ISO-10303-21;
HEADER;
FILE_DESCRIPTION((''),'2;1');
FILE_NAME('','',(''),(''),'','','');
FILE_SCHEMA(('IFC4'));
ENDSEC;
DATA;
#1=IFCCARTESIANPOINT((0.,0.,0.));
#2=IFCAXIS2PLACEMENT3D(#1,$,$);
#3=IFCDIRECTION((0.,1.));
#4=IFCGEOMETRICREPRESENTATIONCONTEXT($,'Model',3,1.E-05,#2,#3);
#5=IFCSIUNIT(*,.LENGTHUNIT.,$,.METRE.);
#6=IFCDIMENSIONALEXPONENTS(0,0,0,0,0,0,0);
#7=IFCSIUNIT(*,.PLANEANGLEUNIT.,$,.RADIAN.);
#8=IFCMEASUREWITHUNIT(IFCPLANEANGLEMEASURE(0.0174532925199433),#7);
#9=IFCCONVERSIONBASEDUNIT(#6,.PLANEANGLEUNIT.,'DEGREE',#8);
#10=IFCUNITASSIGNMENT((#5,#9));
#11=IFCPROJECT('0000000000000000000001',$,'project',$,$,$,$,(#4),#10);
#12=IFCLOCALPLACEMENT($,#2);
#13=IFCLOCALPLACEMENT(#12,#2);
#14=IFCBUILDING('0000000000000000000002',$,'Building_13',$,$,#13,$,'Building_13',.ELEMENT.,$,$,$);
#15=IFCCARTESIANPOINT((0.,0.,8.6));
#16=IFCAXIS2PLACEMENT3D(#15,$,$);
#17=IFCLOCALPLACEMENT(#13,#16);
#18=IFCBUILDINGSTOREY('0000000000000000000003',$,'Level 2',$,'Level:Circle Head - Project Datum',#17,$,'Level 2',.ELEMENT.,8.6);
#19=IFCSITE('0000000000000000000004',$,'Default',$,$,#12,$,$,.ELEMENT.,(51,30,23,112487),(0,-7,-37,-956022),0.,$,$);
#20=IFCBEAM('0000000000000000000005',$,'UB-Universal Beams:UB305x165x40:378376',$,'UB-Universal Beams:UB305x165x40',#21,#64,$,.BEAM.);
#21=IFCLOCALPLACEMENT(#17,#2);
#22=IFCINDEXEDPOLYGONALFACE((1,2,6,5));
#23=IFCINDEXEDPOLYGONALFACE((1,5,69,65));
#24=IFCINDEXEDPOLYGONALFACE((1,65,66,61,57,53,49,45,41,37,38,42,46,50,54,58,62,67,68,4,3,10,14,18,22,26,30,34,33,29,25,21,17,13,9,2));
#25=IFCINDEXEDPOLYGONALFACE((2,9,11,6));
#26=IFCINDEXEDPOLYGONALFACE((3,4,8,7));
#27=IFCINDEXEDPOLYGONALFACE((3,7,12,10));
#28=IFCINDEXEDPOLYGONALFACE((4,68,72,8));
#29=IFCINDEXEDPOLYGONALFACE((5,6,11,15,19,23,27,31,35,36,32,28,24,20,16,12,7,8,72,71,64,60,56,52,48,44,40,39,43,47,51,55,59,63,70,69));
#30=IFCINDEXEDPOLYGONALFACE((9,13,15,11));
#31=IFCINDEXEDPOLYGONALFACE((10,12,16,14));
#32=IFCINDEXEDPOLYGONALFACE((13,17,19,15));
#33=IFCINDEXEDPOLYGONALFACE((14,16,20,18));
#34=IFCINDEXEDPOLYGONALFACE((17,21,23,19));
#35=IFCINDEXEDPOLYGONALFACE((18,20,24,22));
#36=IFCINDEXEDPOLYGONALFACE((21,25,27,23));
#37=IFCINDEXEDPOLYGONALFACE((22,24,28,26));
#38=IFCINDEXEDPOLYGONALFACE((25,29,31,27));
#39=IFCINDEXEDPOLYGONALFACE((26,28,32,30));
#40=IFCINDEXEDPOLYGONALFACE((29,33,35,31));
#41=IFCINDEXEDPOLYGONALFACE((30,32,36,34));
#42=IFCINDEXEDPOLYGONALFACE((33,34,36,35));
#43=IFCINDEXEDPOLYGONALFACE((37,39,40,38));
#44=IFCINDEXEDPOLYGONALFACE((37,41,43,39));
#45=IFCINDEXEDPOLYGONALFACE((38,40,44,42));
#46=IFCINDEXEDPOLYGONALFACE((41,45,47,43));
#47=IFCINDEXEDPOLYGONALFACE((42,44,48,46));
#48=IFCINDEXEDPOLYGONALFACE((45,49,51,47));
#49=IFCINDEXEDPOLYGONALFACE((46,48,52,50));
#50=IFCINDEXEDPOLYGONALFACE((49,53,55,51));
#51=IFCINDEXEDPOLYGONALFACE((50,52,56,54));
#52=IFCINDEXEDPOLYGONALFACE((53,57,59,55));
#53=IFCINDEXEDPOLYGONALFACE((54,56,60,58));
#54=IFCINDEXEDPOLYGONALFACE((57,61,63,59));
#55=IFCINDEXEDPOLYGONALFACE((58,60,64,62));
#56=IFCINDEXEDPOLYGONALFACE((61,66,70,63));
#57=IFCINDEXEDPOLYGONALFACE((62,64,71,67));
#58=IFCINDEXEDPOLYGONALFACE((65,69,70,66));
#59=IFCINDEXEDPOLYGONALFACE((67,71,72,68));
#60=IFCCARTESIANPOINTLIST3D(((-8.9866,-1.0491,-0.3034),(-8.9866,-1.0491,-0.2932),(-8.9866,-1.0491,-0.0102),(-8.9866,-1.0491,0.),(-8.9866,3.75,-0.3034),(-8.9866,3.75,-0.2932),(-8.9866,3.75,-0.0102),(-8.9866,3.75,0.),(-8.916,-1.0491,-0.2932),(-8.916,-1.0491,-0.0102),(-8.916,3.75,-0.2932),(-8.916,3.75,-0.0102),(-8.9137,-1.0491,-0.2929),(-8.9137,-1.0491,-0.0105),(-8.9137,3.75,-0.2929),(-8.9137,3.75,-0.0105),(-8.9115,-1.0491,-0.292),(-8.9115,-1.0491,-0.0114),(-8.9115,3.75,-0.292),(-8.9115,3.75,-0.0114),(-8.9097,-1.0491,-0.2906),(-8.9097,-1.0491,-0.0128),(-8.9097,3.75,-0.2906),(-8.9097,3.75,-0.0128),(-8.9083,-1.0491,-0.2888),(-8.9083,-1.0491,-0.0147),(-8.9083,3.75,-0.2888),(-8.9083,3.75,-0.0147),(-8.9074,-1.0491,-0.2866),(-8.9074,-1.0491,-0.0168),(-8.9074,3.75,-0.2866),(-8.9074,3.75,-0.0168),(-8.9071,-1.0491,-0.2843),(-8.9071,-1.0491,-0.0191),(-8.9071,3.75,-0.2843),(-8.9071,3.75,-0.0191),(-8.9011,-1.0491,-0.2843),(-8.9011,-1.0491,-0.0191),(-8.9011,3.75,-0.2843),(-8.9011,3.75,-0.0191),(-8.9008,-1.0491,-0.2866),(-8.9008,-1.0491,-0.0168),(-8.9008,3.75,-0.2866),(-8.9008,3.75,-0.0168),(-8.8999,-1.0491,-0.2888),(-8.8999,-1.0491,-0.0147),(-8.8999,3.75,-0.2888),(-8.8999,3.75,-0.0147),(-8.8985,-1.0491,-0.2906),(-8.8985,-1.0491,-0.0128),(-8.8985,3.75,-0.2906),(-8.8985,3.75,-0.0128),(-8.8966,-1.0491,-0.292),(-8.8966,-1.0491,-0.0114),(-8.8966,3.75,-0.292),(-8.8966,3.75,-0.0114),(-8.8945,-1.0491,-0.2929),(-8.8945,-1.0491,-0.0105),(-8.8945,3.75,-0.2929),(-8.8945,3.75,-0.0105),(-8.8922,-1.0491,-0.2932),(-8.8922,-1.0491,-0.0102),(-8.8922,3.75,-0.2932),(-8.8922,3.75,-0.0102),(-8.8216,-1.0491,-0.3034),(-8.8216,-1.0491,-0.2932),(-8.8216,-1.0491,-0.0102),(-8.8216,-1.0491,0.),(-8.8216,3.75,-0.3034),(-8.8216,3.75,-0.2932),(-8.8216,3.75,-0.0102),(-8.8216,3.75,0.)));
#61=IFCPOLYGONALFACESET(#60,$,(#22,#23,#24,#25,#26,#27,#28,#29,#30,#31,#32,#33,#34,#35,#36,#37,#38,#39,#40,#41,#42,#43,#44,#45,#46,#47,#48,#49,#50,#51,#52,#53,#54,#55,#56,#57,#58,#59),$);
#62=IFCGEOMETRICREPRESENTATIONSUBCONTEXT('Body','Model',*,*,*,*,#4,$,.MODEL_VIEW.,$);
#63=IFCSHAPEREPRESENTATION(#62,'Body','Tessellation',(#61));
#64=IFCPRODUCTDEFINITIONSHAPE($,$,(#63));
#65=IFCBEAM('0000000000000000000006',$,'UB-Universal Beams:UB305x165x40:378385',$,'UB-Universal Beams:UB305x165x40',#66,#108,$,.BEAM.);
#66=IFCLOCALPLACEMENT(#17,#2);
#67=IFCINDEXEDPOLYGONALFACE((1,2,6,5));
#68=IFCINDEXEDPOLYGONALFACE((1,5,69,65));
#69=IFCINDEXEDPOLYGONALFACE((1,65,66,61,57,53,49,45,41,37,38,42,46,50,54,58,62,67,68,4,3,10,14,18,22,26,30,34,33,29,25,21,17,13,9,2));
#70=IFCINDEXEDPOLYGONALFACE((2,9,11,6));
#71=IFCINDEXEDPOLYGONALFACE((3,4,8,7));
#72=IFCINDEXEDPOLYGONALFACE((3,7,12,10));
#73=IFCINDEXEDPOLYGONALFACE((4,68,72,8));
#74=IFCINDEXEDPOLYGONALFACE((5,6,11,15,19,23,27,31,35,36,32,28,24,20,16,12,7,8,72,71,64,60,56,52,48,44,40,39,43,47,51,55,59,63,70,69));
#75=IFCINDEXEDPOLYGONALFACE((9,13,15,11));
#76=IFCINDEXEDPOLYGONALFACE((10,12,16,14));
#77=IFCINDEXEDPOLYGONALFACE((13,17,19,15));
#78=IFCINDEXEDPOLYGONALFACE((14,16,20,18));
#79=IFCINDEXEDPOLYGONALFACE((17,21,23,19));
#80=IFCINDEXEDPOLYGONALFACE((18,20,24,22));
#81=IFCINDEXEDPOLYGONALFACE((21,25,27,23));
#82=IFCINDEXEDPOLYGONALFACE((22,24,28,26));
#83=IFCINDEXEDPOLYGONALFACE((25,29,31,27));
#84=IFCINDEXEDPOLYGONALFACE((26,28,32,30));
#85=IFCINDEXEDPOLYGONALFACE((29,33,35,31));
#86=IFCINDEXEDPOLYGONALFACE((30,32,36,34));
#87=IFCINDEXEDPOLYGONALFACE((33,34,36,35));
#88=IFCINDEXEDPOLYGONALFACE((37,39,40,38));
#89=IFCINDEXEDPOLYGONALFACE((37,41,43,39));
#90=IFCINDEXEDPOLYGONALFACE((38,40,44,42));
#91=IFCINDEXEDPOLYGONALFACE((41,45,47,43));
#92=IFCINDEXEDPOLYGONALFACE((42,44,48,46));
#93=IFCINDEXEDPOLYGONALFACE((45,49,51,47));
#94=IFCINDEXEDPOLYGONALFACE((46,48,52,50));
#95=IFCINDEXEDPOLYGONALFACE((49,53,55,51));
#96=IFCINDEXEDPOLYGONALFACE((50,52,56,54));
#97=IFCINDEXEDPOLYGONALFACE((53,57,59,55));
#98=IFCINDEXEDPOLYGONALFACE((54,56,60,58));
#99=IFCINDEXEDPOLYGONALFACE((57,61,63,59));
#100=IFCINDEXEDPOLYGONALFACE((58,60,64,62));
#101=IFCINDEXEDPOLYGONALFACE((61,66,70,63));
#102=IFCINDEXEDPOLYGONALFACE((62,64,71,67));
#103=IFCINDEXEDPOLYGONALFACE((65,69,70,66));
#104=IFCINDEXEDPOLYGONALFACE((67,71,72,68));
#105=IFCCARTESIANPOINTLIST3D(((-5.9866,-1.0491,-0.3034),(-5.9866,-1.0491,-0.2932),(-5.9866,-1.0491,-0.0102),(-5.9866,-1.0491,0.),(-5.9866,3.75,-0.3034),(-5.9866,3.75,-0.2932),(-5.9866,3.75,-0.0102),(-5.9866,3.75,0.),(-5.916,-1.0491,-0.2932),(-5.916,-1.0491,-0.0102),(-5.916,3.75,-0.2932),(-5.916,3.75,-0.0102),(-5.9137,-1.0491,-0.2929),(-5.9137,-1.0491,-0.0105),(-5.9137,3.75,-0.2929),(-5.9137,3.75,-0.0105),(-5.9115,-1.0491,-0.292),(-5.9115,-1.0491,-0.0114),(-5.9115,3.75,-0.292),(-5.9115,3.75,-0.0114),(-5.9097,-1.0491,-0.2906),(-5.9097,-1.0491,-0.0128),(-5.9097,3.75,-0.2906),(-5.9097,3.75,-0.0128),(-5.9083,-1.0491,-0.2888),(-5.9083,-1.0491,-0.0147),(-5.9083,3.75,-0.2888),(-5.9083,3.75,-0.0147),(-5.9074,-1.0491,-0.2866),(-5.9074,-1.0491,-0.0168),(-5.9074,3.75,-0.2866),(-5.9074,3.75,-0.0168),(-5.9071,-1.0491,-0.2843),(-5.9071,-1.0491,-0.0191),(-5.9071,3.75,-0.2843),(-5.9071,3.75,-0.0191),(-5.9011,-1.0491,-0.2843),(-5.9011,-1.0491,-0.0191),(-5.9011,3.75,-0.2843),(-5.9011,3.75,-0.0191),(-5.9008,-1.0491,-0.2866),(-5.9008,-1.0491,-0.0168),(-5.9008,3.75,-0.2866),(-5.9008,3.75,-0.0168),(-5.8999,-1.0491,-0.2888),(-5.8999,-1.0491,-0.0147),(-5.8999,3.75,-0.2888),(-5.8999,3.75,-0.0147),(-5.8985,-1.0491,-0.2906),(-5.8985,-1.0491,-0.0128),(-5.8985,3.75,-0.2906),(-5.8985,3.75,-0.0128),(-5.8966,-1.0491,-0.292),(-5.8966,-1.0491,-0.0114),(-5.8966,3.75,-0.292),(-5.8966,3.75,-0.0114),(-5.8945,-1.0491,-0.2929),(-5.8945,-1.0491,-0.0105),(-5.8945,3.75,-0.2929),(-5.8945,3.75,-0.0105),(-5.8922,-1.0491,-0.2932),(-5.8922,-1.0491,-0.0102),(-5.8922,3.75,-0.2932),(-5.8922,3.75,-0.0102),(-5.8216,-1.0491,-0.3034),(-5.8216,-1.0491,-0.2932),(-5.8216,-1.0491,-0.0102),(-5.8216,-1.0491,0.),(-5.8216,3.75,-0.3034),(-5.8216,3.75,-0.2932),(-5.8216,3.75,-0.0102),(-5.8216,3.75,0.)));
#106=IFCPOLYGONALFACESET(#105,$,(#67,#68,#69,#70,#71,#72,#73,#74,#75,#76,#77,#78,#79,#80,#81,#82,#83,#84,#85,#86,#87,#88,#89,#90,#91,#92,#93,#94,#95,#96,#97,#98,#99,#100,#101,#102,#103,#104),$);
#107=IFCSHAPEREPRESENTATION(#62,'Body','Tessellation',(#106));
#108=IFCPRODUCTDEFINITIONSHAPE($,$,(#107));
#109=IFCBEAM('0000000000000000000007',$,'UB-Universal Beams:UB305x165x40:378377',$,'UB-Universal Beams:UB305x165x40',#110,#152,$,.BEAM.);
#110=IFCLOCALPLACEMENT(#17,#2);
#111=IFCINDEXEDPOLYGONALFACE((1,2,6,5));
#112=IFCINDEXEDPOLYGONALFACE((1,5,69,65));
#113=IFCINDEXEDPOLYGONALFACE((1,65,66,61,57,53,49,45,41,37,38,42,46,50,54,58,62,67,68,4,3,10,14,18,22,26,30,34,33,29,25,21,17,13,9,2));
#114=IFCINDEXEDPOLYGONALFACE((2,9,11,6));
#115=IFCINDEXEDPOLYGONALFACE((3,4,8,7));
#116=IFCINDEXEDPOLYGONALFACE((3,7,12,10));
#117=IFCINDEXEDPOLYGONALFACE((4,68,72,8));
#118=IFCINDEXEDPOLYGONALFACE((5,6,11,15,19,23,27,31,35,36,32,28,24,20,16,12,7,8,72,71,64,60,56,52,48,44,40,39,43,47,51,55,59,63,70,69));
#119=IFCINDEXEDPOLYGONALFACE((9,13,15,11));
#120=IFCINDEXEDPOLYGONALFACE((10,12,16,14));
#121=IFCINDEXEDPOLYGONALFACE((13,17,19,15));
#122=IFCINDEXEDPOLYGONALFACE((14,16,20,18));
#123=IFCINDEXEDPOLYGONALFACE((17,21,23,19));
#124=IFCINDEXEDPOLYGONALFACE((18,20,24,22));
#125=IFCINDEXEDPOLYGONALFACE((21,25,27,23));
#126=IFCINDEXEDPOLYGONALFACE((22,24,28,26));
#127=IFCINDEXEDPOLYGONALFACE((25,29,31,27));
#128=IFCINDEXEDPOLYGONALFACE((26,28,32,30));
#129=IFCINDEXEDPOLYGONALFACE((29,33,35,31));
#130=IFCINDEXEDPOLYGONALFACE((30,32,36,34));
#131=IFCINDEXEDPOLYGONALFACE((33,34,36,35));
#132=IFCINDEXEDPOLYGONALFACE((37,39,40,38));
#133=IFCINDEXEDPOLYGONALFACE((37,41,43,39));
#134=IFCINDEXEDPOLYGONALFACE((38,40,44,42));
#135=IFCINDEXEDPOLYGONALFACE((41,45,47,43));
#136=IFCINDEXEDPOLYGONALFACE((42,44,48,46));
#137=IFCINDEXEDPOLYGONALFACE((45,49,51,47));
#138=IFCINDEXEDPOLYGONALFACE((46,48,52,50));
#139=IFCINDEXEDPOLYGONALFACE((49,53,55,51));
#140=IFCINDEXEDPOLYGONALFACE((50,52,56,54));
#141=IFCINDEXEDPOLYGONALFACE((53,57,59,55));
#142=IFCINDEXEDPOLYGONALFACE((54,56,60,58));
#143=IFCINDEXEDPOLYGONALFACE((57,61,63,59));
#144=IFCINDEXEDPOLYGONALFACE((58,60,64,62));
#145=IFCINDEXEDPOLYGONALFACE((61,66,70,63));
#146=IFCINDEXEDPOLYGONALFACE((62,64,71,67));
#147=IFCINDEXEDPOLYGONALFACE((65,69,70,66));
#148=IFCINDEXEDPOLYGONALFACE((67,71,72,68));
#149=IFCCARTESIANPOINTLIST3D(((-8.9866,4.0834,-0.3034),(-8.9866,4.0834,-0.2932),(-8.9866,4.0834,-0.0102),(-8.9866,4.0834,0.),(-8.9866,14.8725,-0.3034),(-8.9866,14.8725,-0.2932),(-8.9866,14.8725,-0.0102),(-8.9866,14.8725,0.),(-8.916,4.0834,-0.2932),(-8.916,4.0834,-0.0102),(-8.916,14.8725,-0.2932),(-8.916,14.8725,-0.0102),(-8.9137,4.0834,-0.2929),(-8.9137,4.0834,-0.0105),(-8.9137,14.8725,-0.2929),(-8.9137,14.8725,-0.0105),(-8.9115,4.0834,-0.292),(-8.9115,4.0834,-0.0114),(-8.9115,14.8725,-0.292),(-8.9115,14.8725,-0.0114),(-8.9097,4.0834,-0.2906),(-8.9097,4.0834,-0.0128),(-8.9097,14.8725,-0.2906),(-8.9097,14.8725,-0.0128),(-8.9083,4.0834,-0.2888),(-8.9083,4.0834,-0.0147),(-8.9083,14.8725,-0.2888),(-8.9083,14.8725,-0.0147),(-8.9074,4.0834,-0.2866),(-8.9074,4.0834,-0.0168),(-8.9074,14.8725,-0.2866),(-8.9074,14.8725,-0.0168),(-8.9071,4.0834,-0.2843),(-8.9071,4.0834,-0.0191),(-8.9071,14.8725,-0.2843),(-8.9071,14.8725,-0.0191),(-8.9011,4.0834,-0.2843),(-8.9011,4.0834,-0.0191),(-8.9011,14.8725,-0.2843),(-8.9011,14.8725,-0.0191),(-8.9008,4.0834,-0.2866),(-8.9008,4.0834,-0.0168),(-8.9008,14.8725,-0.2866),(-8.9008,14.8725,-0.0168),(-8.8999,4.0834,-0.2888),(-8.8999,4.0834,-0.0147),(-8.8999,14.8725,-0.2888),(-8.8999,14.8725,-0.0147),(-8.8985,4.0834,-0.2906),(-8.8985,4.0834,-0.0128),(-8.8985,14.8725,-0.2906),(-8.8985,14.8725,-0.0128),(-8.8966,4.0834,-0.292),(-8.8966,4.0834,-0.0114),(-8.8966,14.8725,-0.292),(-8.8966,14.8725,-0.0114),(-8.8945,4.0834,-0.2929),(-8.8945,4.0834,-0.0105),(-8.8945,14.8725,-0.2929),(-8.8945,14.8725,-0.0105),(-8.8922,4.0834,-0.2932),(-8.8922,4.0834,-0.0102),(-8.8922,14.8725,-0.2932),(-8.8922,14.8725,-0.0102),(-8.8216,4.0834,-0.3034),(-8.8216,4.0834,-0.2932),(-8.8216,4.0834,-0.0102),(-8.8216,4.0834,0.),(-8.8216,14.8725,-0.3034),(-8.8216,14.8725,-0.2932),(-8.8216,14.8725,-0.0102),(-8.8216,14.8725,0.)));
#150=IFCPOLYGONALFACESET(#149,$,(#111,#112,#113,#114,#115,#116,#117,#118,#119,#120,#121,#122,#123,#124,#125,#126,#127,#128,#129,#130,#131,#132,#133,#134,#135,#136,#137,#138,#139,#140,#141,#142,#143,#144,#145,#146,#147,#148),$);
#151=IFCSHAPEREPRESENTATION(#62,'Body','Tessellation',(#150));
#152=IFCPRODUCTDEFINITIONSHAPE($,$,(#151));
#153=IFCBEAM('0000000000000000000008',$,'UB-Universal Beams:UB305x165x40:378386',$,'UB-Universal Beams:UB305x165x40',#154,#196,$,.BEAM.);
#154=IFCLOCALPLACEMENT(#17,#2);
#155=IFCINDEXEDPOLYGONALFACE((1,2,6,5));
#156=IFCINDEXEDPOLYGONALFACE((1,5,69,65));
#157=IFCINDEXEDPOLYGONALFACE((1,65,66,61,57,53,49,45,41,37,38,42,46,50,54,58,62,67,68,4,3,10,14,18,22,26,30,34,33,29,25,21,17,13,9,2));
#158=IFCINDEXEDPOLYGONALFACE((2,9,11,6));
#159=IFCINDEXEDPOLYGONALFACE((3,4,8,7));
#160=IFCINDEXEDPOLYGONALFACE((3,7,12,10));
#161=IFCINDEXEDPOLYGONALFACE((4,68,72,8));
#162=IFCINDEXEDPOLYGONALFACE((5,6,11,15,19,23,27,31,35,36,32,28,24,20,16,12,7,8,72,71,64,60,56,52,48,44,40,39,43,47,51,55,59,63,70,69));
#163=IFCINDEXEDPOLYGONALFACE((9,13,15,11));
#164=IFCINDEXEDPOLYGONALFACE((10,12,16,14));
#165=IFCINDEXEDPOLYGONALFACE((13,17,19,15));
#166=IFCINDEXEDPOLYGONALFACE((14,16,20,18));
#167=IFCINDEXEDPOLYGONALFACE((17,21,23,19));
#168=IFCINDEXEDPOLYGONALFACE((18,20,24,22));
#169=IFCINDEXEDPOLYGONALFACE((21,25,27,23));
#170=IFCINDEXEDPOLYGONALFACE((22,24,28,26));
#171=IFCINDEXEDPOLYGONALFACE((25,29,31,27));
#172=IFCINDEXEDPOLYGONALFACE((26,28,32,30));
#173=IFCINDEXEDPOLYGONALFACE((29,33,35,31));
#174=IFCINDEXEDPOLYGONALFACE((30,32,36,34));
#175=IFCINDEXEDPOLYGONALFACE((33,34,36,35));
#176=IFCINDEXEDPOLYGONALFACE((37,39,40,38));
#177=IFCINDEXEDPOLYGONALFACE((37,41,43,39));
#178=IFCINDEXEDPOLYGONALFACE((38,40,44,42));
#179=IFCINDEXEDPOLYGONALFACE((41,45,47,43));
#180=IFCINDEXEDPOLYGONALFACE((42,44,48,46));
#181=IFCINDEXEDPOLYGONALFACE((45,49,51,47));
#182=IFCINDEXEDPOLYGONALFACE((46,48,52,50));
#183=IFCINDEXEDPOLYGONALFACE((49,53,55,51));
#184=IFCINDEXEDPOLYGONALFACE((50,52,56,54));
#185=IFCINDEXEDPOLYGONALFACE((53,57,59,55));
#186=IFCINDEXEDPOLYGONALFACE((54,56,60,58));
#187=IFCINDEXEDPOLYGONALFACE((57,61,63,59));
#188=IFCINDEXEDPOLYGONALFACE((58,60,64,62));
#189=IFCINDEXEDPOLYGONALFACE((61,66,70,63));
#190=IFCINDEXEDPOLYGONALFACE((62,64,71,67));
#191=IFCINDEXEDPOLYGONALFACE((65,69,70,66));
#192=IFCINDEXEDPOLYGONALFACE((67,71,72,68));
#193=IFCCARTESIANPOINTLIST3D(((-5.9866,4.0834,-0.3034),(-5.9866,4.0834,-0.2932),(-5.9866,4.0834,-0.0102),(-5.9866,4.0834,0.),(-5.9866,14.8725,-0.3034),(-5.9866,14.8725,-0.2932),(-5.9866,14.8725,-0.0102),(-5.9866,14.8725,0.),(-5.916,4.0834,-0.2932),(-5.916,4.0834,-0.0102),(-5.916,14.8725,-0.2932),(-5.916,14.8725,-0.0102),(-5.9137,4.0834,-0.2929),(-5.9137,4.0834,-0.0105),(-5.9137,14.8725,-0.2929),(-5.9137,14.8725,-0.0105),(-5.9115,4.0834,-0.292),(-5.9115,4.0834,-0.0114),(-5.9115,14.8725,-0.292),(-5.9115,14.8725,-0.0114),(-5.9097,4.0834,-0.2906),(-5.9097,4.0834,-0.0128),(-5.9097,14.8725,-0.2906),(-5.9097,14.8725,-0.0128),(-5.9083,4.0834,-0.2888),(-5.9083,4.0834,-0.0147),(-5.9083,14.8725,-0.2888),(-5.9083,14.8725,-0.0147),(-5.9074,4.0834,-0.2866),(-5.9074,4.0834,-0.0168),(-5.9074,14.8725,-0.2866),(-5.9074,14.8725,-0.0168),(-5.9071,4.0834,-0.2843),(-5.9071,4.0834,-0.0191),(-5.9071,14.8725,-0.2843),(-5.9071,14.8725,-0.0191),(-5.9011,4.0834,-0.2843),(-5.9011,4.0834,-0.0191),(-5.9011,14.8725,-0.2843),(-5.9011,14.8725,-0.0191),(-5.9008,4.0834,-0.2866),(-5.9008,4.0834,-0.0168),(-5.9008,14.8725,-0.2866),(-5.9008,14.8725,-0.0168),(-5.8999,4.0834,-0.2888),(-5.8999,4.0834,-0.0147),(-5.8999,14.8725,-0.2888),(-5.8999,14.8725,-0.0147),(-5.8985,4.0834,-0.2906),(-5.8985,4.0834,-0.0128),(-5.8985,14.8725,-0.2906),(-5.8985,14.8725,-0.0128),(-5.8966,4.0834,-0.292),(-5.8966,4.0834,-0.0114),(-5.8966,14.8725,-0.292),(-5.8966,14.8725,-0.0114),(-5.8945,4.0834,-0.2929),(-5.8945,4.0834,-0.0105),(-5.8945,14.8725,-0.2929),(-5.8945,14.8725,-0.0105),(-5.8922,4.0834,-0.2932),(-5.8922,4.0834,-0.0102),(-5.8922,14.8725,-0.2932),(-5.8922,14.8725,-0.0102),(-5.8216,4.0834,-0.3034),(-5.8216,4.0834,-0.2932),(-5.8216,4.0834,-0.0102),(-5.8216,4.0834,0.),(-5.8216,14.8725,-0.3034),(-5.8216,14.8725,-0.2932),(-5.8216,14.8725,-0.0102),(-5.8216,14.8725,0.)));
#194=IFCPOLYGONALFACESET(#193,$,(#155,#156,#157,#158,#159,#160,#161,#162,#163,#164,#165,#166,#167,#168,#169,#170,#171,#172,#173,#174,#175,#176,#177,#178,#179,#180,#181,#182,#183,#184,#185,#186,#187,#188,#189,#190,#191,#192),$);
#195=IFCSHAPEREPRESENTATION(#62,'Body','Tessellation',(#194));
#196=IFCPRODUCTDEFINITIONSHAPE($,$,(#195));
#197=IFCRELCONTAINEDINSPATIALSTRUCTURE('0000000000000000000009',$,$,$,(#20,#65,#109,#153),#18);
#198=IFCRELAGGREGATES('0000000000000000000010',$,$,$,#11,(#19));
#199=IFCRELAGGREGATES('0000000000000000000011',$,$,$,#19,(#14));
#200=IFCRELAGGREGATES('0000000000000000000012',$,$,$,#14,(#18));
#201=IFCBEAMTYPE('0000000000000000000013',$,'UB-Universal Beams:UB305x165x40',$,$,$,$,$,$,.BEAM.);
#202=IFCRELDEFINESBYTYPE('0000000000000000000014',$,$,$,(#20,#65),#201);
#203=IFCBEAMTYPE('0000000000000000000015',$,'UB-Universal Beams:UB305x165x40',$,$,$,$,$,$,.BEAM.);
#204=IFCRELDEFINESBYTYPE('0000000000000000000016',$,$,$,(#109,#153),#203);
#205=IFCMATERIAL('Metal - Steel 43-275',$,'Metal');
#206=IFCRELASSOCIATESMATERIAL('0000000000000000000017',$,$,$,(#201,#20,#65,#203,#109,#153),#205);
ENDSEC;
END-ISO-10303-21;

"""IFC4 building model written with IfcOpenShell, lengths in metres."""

from ifc_helpers import new_model, entity, si_unit, converted_unit, direction, frame, origin, place, context, subcontext, project, spatial, line, arc, indexed_curve, outline, extrude, source, transform, mapped, material, type_object, type_shapes, element, save


model = new_model("IFC4")

# Units and contexts
model_context = context("Model", 3, precision=1e-05, world=origin(), true_north=direction((0.0, 1.0)))
body_context = subcontext(model_context, "Body", "Model", "MODEL_VIEW")
ifc_project = project(units=[si_unit("LENGTHUNIT", "METRE"), converted_unit("PLANEANGLEUNIT", "DEGREE", entity("IfcPlaneAngleMeasure", 0.0174532925199433), si_unit("PLANEANGLEUNIT", "RADIAN"), dimensions=[0, 0, 0, 0, 0, 0, 0])], contexts=[model_context])

# Site, building, storey
site_placement = place(None, origin())
site = spatial("IfcSite", under=ifc_project, at=site_placement, Name="Default", CompositionType="ELEMENT", RefLatitude=(51, 30, 23, 112487), RefLongitude=(0, -7, -37, -956022), RefElevation=0.0)
building_placement = place(site_placement, origin())
building = spatial("IfcBuilding", under=site, at=building_placement, Name="Building_13", LongName="Building_13", CompositionType="ELEMENT")
storey_placement = place(building_placement, frame((0.0, 0.0, 8.6)))
storey = spatial("IfcBuildingStorey", under=building, at=storey_placement, Name="Level 2", ObjectType="Level:Circle Head - Project Datum", LongName="Level 2", CompositionType="ELEMENT", Elevation=8.6)

# Beams
ifc_material_1 = material(Name="Metal - Steel 43-275", Category="Metal")
beam_type_1 = type_object("IfcBeamType", Name="UB-Universal Beams:UB305x165x40", PredefinedType="BEAM", material=ifc_material_1)
shared_shape_1 = source(origin(), body_context, "Body", "SweptSolid", [
    extrude(outline(indexed_curve([(-0.0825, -0.1415), (-0.0825, -0.1517), (0.0825, -0.1517), (0.0825, -0.1415), (0.0119, -0.1415), (0.0056, -0.1389), (0.003, -0.1326), (0.003, 0.1326), (0.0056, 0.1389), (0.0119, 0.1415), (0.0825, 0.1415), (0.0825, 0.1517), (-0.0825, 0.1517), (-0.0825, 0.1415), (-0.0119, 0.1415), (-0.0056, 0.1389), (-0.003, 0.1326), (-0.003, -0.1326), (-0.0056, -0.1389), (-0.0119, -0.1415)], segments=[line(1, 2, 3, 4, 5), arc(5, 6, 7), line(7, 8), arc(8, 9, 10), line(10, 11, 12, 13, 14, 15), arc(15, 16, 17), line(17, 18), arc(18, 19, 20), line(20, 1)], self_intersect=False)), frame((-2.3996, 0.0, 0.0), z_axis=(-1.0, 0.0, 0.0), x_axis=(0.0, -1.0, 0.0)), (0.0, 0.0, -1.0), 4.7991),
])
type_shapes(beam_type_1, [shared_shape_1])
for number, where, z_axis, x_axis, name in (
    (1, (-8.9041, 1.3504, -0.1517), (0.0, 0.0, 1.0), (0.0, -1.0, 0.0), "UB-Universal Beams:UB305x165x40:378376"),
    (2, (-5.9041, 1.3504, -0.1517), (0.0, 0.0, 1.0), (0.0, 1.0, 0.0), "UB-Universal Beams:UB305x165x40:378385"),
):
    element("IfcBeam", number, at=place(storey_placement, frame(where, z_axis=z_axis, x_axis=x_axis)), inside=storey, type_object=beam_type_1, material=ifc_material_1, Name=name, ObjectType="UB-Universal Beams:UB305x165x40", PredefinedType="BEAM", context=body_context, shape_type="MappedRepresentation", body=[
        mapped(shared_shape_1, transform((0.0, 0.0, 0.0), scale=1.0)),
    ])
beam_type_2 = type_object("IfcBeamType", Name="UB-Universal Beams:UB305x165x40", PredefinedType="BEAM", material=ifc_material_1)
shared_shape_2 = source(origin(), body_context, "Body", "SweptSolid", [
    extrude(outline(indexed_curve([(-0.0825, -0.1415), (-0.0825, -0.1517), (0.0825, -0.1517), (0.0825, -0.1415), (0.0119, -0.1415), (0.0056, -0.1389), (0.003, -0.1326), (0.003, 0.1326), (0.0056, 0.1389), (0.0119, 0.1415), (0.0825, 0.1415), (0.0825, 0.1517), (-0.0825, 0.1517), (-0.0825, 0.1415), (-0.0119, 0.1415), (-0.0056, 0.1389), (-0.003, 0.1326), (-0.003, -0.1326), (-0.0056, -0.1389), (-0.0119, -0.1415)], segments=[line(1, 2, 3, 4, 5), arc(5, 6, 7), line(7, 8), arc(8, 9, 10), line(10, 11, 12, 13, 14, 15), arc(15, 16, 17), line(17, 18), arc(18, 19, 20), line(20, 1)], self_intersect=False)), frame((-5.3945, 0.0, 0.0), z_axis=(-1.0, 0.0, 0.0), x_axis=(0.0, -1.0, 0.0)), (0.0, 0.0, -1.0), 10.7891),
])
type_shapes(beam_type_2, [shared_shape_2])
for number, where, z_axis, x_axis, name in (
    (3, (-8.9041, 9.4779, -0.1517), (0.0, 0.0, 1.0), (0.0, -1.0, 0.0), "UB-Universal Beams:UB305x165x40:378377"),
    (4, (-5.9041, 9.4779, -0.1517), (0.0, 0.0, 1.0), (0.0, -1.0, 0.0), "UB-Universal Beams:UB305x165x40:378386"),
):
    element("IfcBeam", number, at=place(storey_placement, frame(where, z_axis=z_axis, x_axis=x_axis)), inside=storey, type_object=beam_type_2, material=ifc_material_1, Name=name, ObjectType="UB-Universal Beams:UB305x165x40", PredefinedType="BEAM", context=body_context, shape_type="MappedRepresentation", body=[
        mapped(shared_shape_2, transform((0.0, 0.0, 0.0), scale=1.0)),
    ])

save(model, "model.ifc")
